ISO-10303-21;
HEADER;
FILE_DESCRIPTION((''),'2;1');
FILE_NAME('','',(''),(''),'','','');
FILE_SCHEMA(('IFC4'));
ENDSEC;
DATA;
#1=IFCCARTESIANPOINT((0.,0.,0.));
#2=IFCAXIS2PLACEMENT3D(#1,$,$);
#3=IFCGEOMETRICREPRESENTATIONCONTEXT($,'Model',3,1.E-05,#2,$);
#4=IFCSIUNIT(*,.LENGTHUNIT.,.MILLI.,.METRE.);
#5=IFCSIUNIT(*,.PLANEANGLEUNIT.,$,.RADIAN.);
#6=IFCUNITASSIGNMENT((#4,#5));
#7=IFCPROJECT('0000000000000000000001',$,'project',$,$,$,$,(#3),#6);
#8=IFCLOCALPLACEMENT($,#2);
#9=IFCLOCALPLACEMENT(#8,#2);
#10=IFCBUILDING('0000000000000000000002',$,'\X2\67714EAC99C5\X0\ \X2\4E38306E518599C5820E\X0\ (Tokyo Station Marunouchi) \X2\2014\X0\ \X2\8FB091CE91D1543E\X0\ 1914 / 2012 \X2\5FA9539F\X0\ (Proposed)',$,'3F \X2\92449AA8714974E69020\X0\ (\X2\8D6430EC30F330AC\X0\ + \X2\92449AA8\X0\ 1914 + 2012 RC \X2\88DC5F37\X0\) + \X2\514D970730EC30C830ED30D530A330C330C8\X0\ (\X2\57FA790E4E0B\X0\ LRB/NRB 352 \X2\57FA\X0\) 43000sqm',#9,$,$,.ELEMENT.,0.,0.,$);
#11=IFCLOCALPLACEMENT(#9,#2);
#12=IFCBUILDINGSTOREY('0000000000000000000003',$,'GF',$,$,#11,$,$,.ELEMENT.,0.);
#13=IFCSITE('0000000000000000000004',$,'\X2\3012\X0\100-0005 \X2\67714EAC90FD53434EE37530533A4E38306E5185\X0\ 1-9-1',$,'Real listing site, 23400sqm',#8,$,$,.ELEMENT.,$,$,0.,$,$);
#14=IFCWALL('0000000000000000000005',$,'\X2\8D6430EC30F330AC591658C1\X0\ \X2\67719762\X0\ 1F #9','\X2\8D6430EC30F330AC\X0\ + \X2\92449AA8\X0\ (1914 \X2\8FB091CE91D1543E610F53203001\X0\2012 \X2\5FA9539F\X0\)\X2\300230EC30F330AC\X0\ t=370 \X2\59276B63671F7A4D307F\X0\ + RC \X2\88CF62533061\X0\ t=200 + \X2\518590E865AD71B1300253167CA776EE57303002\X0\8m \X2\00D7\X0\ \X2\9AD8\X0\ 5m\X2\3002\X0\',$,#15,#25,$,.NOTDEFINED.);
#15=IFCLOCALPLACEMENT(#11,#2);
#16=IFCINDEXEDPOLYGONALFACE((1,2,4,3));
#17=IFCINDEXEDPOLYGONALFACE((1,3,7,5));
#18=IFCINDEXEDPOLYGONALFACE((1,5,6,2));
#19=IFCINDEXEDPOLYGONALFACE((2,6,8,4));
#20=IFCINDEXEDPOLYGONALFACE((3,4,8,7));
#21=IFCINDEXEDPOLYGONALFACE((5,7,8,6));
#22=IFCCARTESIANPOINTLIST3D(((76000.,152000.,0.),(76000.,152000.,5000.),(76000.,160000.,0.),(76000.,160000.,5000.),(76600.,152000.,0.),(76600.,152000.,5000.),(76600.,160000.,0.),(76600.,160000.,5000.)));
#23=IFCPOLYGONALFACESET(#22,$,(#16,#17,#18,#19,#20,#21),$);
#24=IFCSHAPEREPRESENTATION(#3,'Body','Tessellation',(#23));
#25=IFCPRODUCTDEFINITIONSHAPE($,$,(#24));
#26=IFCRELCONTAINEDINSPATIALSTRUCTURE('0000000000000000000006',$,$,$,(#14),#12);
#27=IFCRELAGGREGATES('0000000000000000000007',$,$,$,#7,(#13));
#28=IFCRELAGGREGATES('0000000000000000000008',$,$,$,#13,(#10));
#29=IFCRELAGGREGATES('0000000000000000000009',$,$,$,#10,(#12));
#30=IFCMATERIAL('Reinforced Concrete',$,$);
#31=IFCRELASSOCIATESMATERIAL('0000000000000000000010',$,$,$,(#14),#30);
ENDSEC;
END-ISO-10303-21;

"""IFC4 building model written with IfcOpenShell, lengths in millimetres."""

from ifc_helpers import new_model, si_unit, frame, frame_2d, origin, place, context, project, spatial, rectangle, extrude, material, element, save


model = new_model("IFC4")

# Units and contexts
model_context = context("Model", 3, precision=1e-05, world=origin())
ifc_project = project(units=[si_unit("LENGTHUNIT", "METRE", prefix="MILLI"), si_unit("PLANEANGLEUNIT", "RADIAN")], contexts=[model_context])

# Site, building, storey
site_placement = place(None, origin())
site = spatial("IfcSite", under=ifc_project, at=site_placement, Name="〒100-0005 東京都千代田区丸の内 1-9-1", ObjectType="Real listing site, 23400sqm", CompositionType="ELEMENT", RefElevation=0.0)
building_placement = place(site_placement, origin())
building = spatial("IfcBuilding", under=site, at=building_placement, Name="東京駅 丸の内駅舎 (Tokyo Station Marunouchi) — 辰野金吾 1914 / 2012 復原 (Proposed)", ObjectType="3F 鉄骨煉瓦造 (赤レンガ + 鉄骨 1914 + 2012 RC 補強) + 免震レトロフィット (基礎下 LRB/NRB 352 基) 43000sqm", CompositionType="ELEMENT", ElevationOfRefHeight=0.0, ElevationOfTerrain=0.0)
storey_placement = place(building_placement, origin())
storey = spatial("IfcBuildingStorey", under=building, at=storey_placement, Name="GF", CompositionType="ELEMENT", Elevation=0.0)

# Shared definitions
ifc_material_1 = material(Name="Reinforced Concrete")

# Wall
wall_1_placement = place(storey_placement, frame((38000.0, 76000.0, 0.0)))
element("IfcWall", 1, at=wall_1_placement, inside=storey, material=ifc_material_1, Name="赤レンガ外壁 東面 1F #9", Description="赤レンガ + 鉄骨 (1914 辰野金吾意匠、2012 復原)。レンガ t=370 大正期積み + RC 裏打ち t=200 + 内部断熱。化粧目地。8m × 高 5m。", PredefinedType="NOTDEFINED", context=model_context, shape_type="SweptSolid", body=[
    extrude(rectangle(XDim=600.0, YDim=8000.0, at=frame_2d((300.0, 4000.0))), frame((38000.0, 76000.0, 0.0)), (0.0, 0.0, 1.0), 5000.0),
])

save(model, "model.ifc")
